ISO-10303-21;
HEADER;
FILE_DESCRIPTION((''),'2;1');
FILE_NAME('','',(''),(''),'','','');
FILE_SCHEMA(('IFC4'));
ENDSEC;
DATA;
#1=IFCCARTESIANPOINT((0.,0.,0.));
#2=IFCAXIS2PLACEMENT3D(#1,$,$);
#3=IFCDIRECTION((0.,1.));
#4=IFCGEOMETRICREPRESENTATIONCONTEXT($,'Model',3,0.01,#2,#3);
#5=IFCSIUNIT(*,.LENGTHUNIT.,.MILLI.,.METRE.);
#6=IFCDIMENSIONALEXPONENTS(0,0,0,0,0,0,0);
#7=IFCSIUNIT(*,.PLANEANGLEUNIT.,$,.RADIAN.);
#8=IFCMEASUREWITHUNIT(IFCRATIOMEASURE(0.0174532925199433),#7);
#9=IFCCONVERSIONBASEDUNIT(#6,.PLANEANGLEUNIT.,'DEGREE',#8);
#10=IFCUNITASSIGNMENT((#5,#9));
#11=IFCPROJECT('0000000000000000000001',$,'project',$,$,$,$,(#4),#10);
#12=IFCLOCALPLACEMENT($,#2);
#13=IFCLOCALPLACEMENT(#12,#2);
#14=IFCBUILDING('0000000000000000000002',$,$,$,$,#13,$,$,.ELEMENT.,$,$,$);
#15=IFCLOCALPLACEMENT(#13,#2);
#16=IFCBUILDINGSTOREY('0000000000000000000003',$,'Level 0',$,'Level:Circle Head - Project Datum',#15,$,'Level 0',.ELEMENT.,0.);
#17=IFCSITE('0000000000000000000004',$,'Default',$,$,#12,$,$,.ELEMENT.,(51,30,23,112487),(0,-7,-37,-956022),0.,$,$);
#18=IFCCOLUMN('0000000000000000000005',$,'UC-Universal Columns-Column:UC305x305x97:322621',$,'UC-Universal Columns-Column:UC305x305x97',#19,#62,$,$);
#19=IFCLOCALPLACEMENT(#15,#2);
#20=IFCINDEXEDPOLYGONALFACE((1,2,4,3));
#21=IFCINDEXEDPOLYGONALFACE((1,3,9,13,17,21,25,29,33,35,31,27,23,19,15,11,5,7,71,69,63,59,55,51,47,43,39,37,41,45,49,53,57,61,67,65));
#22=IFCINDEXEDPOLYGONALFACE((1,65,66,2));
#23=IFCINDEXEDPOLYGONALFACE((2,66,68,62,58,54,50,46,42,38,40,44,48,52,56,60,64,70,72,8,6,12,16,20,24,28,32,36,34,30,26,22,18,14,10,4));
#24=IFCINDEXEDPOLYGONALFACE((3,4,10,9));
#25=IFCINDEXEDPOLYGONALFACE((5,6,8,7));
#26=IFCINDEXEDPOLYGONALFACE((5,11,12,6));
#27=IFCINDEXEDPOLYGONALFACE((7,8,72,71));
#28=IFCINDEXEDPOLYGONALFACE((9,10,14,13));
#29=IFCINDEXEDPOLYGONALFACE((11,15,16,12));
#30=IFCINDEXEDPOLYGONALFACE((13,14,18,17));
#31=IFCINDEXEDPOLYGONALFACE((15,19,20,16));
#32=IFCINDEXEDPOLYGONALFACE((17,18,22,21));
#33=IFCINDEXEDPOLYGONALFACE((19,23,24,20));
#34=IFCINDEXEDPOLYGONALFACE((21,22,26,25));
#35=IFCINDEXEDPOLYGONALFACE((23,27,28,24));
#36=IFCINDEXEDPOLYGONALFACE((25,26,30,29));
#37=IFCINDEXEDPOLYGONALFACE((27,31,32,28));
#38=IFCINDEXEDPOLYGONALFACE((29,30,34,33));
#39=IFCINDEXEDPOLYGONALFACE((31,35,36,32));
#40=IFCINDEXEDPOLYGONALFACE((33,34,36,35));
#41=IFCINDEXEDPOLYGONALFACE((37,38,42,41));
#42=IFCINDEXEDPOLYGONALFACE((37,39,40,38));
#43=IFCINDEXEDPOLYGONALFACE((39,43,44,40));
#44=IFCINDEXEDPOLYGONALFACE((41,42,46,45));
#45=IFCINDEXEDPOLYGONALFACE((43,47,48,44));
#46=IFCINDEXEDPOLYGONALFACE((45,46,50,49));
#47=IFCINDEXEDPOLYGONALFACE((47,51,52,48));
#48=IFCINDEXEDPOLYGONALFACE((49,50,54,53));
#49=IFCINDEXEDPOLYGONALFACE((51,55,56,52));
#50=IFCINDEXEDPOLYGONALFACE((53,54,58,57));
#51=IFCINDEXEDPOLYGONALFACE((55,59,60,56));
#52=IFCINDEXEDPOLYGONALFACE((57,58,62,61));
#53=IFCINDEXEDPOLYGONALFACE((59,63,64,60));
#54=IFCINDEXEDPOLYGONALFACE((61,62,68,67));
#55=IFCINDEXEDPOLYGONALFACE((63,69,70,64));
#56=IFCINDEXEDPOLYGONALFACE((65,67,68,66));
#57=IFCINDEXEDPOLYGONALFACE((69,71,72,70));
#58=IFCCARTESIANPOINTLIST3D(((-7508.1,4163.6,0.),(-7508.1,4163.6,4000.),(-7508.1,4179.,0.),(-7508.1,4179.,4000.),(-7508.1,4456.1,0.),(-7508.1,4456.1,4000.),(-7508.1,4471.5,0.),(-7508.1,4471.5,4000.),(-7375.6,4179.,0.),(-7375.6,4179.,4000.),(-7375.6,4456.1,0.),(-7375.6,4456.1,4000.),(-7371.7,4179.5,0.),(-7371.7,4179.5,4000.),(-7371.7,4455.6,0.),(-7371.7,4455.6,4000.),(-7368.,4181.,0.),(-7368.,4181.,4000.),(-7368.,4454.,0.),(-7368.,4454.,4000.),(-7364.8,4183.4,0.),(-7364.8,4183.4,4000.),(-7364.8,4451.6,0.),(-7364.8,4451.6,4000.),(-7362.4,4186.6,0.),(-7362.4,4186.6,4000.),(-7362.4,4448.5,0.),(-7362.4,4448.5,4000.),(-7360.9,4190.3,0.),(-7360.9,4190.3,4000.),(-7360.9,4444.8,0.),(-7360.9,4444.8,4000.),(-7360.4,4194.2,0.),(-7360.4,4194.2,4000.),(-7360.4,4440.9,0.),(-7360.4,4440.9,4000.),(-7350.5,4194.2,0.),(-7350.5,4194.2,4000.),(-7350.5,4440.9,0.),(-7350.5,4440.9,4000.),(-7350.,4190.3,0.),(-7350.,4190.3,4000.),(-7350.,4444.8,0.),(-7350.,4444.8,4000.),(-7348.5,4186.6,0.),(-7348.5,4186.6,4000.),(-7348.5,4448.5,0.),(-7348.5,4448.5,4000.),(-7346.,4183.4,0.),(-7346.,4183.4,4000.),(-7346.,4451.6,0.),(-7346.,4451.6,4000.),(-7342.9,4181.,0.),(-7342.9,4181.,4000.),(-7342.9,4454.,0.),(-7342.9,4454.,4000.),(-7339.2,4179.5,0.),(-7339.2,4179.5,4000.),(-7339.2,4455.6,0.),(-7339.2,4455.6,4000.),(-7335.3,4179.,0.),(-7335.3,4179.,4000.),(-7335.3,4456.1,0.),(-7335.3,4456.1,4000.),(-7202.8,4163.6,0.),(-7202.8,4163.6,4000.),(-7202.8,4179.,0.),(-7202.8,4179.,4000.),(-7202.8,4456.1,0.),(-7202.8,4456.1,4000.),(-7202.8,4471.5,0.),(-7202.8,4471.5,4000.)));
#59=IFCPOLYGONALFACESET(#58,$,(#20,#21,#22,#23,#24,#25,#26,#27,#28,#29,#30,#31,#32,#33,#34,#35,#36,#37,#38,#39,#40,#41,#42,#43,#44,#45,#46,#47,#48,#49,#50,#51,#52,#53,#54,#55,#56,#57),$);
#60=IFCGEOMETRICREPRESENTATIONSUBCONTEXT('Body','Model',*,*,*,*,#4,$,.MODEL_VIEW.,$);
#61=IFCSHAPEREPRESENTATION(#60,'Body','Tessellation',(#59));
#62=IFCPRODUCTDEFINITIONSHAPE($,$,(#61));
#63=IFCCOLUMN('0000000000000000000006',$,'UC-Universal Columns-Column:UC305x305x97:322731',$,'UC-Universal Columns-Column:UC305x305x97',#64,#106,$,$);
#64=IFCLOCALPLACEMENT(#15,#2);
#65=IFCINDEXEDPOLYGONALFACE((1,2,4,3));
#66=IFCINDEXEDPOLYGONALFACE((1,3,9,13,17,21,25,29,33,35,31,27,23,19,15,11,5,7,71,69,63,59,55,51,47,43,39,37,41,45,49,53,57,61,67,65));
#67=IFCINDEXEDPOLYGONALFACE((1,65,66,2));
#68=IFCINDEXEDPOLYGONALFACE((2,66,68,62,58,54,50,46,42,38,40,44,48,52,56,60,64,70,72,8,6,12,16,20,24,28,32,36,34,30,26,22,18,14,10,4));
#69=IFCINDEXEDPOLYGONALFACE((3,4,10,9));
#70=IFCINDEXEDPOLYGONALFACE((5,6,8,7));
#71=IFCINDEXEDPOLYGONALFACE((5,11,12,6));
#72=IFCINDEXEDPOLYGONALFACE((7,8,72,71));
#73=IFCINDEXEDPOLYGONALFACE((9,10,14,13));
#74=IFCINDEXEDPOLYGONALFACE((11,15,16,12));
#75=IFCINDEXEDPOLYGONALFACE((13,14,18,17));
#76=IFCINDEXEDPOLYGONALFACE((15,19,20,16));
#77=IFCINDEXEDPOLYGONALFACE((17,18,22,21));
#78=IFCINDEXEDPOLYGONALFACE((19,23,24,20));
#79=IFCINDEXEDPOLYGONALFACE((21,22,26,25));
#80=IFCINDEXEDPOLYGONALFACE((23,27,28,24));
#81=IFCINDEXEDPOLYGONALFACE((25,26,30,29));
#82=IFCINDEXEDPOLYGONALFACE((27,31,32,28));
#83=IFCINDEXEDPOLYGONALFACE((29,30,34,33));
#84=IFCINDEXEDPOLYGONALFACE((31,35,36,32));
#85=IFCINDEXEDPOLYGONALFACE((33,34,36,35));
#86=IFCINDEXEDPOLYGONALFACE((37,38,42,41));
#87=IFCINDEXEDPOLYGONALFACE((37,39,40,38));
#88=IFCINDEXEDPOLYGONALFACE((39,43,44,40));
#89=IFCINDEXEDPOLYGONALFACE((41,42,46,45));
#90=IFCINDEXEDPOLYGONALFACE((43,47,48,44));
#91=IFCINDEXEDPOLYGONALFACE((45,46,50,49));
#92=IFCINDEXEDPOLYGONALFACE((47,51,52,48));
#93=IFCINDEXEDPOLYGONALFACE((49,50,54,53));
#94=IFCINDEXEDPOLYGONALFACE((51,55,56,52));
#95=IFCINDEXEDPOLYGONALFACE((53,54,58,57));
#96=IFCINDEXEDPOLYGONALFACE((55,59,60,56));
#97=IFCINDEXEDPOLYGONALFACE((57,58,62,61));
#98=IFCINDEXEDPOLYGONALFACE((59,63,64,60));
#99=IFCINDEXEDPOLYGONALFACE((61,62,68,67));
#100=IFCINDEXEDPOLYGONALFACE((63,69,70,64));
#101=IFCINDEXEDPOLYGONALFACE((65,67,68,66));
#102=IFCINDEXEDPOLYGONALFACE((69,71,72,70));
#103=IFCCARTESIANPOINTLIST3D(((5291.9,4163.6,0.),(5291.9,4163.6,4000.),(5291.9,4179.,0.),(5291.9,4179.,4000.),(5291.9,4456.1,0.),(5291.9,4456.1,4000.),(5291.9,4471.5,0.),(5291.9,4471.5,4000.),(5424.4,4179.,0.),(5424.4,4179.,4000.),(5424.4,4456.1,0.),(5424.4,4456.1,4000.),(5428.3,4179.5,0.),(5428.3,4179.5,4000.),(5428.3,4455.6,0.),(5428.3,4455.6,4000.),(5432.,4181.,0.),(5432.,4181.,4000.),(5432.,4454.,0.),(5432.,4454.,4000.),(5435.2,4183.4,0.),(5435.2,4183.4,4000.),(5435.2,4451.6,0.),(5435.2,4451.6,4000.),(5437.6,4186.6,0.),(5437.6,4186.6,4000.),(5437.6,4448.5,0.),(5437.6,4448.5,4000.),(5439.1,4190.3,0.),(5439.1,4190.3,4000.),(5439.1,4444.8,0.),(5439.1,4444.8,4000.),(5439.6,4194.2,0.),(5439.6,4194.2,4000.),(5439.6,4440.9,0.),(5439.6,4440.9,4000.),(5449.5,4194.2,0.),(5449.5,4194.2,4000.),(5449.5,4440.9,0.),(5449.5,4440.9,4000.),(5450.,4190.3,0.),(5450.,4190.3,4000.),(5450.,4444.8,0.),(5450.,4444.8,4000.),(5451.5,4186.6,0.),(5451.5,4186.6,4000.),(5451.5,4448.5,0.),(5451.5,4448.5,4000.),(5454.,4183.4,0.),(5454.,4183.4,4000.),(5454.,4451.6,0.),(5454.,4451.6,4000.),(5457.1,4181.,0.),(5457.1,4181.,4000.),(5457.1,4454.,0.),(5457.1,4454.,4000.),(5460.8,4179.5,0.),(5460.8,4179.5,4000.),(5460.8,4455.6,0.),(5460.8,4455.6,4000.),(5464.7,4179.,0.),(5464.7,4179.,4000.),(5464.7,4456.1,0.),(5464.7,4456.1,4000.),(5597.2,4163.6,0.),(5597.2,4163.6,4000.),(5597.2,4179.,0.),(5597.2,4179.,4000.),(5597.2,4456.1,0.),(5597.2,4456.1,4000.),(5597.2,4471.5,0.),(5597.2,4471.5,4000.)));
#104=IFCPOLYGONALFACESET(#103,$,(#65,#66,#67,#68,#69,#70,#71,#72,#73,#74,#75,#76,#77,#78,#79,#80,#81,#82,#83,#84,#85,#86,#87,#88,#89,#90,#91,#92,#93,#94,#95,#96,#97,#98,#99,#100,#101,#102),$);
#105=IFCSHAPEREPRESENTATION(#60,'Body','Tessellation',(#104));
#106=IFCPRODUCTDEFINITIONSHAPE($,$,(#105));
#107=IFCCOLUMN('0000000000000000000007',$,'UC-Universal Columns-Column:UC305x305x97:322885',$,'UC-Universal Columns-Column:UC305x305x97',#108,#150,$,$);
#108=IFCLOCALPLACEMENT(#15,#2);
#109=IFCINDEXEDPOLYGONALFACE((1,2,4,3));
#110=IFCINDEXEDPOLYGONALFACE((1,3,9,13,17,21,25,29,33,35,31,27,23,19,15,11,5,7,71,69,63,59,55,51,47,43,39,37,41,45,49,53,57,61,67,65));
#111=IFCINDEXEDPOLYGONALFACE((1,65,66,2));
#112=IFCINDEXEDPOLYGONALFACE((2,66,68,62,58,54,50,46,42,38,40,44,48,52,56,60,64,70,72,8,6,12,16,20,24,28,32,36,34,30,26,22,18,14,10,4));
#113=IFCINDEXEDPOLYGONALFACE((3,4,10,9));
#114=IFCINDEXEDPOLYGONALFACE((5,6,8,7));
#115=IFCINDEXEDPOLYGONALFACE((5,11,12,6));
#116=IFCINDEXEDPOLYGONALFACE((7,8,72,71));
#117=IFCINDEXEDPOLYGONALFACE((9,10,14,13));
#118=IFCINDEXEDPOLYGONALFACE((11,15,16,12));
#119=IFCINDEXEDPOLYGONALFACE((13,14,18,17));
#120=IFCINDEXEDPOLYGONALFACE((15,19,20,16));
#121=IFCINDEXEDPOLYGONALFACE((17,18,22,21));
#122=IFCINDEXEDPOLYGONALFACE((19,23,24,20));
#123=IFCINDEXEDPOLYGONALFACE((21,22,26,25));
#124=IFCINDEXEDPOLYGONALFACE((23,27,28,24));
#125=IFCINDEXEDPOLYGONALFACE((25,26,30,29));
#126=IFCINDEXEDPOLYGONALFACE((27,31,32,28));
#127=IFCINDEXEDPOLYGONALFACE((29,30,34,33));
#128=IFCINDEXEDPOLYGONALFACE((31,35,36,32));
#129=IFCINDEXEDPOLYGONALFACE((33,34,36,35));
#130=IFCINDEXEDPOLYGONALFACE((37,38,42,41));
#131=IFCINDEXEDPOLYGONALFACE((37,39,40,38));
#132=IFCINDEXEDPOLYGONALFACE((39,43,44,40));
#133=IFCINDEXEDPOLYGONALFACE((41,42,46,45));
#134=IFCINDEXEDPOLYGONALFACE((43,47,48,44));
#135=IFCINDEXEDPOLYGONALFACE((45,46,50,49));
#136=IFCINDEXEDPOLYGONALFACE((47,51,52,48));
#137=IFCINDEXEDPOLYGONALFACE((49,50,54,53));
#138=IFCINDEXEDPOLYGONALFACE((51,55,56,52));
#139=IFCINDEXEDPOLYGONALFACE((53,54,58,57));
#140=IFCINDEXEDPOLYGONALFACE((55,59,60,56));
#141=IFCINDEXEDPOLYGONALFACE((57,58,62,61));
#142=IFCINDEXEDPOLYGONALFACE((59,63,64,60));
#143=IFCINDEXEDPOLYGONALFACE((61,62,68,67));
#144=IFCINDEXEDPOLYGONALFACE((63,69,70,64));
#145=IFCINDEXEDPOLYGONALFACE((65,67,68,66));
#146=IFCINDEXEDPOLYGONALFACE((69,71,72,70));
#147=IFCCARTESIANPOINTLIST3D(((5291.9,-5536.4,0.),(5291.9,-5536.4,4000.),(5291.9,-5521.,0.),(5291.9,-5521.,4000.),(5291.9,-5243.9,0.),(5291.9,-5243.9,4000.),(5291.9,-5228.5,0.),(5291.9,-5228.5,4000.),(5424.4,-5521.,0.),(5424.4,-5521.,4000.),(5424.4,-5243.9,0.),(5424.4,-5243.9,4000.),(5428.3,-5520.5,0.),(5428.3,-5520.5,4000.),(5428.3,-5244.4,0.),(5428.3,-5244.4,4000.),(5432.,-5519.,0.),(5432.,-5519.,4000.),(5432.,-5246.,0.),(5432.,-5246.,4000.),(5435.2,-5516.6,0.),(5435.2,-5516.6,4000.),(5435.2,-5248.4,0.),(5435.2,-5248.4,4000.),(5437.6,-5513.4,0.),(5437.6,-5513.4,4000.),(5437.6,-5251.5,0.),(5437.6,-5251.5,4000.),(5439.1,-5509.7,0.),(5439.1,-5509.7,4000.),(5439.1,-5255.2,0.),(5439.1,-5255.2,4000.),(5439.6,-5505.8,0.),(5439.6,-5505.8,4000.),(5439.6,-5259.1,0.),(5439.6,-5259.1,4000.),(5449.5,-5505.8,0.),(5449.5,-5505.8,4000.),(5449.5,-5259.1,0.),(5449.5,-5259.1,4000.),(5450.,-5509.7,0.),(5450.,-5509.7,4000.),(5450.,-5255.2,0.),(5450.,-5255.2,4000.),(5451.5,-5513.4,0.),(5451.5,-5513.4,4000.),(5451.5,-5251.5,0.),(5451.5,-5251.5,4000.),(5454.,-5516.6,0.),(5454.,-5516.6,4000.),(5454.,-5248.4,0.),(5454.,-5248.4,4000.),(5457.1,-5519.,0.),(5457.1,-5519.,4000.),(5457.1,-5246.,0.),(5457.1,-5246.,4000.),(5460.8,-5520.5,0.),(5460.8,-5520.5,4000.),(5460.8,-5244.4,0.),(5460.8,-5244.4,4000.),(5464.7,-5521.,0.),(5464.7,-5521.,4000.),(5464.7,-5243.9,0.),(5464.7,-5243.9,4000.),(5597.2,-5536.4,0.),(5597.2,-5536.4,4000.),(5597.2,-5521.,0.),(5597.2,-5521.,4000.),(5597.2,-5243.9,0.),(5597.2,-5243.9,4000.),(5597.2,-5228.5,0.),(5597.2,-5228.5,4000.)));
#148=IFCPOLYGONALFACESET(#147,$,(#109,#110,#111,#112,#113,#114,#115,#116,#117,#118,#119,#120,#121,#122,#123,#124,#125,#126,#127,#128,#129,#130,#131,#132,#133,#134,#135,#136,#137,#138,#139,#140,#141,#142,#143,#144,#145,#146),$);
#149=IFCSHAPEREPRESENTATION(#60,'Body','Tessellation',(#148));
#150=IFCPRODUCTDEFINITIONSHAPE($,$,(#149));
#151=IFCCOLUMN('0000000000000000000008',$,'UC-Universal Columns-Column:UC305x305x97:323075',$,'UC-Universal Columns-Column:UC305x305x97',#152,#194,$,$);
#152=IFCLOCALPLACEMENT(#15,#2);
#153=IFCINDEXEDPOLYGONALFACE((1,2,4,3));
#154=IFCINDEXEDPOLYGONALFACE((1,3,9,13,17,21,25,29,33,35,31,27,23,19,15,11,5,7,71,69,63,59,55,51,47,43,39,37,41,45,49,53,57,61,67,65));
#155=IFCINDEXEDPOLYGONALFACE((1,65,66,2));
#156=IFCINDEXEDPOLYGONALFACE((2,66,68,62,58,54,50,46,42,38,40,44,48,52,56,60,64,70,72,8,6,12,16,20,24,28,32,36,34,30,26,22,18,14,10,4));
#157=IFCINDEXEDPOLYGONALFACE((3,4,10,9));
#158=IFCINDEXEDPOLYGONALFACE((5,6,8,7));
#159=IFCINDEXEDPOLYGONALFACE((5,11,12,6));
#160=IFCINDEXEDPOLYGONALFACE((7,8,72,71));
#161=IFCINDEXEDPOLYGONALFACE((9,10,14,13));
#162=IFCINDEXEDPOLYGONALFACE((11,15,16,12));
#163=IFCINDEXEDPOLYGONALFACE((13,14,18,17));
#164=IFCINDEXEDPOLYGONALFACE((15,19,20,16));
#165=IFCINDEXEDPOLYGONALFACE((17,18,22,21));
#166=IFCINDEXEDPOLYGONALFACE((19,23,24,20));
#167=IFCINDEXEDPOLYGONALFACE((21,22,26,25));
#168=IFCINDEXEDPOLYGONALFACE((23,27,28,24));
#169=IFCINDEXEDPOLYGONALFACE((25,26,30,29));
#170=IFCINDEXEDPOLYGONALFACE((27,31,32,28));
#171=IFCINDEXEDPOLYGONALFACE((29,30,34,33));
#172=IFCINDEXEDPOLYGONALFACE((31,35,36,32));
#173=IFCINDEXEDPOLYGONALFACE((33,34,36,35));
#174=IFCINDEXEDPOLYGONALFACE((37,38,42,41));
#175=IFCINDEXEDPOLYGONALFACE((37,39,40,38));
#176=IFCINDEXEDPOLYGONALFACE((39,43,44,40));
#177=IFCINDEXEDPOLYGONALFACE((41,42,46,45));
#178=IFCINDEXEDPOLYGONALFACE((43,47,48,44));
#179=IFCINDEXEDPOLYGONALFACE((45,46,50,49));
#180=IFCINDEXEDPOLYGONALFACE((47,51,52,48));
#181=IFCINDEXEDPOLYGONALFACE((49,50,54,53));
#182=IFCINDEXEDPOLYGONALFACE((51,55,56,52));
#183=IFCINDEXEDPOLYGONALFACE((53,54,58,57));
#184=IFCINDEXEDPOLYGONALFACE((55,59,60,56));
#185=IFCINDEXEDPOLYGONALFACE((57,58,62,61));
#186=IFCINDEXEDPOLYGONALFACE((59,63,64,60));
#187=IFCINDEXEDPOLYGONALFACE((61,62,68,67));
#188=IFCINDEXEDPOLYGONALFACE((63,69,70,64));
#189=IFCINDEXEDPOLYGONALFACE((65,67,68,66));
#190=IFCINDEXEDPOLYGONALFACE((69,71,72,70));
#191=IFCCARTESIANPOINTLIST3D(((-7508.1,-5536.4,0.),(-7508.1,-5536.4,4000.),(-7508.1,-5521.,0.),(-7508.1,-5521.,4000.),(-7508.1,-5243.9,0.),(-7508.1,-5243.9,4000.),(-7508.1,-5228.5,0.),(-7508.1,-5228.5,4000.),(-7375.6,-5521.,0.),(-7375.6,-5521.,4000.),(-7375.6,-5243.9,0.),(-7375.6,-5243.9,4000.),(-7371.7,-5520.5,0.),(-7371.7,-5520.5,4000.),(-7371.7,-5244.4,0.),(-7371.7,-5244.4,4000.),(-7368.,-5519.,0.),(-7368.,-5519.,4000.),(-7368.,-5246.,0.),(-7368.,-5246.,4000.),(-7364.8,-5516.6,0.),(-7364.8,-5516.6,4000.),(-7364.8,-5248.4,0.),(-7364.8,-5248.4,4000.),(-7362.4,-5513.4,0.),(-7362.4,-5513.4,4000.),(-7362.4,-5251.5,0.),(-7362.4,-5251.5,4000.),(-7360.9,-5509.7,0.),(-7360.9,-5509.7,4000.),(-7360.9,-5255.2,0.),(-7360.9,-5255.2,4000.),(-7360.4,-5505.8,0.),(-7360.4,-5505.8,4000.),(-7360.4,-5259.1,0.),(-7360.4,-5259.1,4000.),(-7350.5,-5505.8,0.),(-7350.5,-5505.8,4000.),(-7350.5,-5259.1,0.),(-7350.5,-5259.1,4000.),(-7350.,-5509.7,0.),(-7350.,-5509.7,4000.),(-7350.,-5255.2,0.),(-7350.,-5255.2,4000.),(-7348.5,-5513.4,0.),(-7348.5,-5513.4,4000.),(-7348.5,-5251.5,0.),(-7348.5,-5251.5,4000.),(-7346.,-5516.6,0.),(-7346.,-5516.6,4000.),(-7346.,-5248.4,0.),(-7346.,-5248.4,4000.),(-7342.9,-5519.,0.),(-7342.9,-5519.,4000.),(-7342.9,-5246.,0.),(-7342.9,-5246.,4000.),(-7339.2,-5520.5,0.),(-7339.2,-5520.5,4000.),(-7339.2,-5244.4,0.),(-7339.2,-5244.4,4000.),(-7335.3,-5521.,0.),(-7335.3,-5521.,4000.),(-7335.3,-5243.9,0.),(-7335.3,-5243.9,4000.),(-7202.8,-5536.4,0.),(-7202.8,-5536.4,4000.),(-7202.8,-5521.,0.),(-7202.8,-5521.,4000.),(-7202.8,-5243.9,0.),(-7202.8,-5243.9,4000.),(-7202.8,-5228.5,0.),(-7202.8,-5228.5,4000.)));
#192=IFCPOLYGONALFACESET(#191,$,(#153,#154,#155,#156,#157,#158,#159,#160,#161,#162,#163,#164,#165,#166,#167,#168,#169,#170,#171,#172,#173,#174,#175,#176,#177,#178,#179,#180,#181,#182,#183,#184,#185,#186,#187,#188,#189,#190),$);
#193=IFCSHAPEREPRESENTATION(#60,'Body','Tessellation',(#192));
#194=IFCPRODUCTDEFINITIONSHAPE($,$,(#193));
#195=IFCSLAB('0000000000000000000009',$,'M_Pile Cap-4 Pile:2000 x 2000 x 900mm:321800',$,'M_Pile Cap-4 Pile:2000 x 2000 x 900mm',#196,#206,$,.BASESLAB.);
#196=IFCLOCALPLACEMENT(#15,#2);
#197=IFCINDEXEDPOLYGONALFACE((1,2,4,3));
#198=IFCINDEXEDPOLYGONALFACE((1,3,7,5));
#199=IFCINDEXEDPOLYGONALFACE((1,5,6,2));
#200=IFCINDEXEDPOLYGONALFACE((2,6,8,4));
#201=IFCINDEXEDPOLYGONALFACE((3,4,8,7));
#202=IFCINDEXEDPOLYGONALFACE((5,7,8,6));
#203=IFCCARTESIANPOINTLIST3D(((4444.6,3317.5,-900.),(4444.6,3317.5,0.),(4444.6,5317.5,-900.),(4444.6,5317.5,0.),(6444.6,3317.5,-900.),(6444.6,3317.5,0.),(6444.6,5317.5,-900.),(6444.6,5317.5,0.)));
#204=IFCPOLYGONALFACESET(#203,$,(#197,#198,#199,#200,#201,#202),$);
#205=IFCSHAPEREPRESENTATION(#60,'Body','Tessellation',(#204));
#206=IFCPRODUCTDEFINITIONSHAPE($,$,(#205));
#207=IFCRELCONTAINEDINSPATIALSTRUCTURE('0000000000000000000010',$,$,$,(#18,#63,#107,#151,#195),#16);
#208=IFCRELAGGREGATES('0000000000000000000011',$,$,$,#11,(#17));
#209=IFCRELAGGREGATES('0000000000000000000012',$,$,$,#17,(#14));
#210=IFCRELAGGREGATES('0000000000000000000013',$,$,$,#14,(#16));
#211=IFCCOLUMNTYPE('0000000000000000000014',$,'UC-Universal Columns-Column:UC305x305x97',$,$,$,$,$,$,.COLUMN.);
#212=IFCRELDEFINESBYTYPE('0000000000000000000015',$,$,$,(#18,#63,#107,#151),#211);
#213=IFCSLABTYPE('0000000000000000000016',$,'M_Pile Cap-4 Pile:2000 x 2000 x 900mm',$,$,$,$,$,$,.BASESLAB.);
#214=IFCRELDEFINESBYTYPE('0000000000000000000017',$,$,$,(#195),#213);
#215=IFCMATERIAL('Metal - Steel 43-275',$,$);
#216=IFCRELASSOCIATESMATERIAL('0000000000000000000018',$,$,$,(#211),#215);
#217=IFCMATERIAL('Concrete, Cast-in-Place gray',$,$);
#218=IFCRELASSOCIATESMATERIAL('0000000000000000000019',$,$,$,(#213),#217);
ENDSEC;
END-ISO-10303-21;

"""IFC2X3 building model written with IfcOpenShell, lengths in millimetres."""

from ifc_helpers import new_model, entity, si_unit, converted_unit, direction, frame, frame_2d, origin, place, context, subcontext, project, spatial, rectangle, i_section, extrude, source, transform, mapped, material, type_object, type_shapes, element, save


model = new_model("IFC2X3")

# Units and contexts
model_context = context("Model", 3, precision=0.01, world=origin(), true_north=direction((0.0, 1.0)))
body_context = subcontext(model_context, "Body", "Model", "MODEL_VIEW")
ifc_project = project(units=[si_unit("LENGTHUNIT", "METRE", prefix="MILLI"), converted_unit("PLANEANGLEUNIT", "DEGREE", entity("IfcRatioMeasure", 0.0174532925199433), si_unit("PLANEANGLEUNIT", "RADIAN"), dimensions=[0, 0, 0, 0, 0, 0, 0])], contexts=[model_context])

# Site, building, storey
site_placement = place(None, origin())
site = spatial("IfcSite", under=ifc_project, at=site_placement, Name="Default", CompositionType="ELEMENT", RefLatitude=(51, 30, 23, 112487), RefLongitude=(0, -7, -37, -956022), RefElevation=0.0)
building_placement = place(site_placement, origin())
building = spatial("IfcBuilding", under=site, at=building_placement, CompositionType="ELEMENT")
storey_placement = place(building_placement, origin())
storey = spatial("IfcBuildingStorey", under=building, at=storey_placement, Name="Level 0", ObjectType="Level:Circle Head - Project Datum", LongName="Level 0", CompositionType="ELEMENT", Elevation=0.0)

# Columns
ifc_material_1 = material(Name="Metal - Steel 43-275")
column_type = type_object("IfcColumnType", Name="UC-Universal Columns-Column:UC305x305x97", PredefinedType="COLUMN", material=ifc_material_1)
shared_shape = source(origin(), body_context, "Body", "SweptSolid", [
    extrude(i_section(OverallWidth=305.3, OverallDepth=307.9, WebThickness=9.9, FlangeThickness=15.4, FilletRadius=15.2, at=frame_2d((0.0, 0.0), x_axis=(0.0, 1.0))), frame((0.0, 0.0, 0.0), z_axis=(0.0, 0.0, 1.0), x_axis=(0.0, -1.0, 0.0)), (0.0, 0.0, 1.0), 4000.0),
])
type_shapes(column_type, [shared_shape])
for number, where, name in (
    (1, (-7355.4, 4317.5, 0.0), "UC-Universal Columns-Column:UC305x305x97:322621"),
    (2, (5444.6, 4317.5, 0.0), "UC-Universal Columns-Column:UC305x305x97:322731"),
    (3, (5444.6, -5382.5, 0.0), "UC-Universal Columns-Column:UC305x305x97:322885"),
    (4, (-7355.4, -5382.5, 0.0), "UC-Universal Columns-Column:UC305x305x97:323075"),
):
    element("IfcColumn", number, at=place(storey_placement, frame(where)), inside=storey, type_object=column_type, Name=name, ObjectType="UC-Universal Columns-Column:UC305x305x97", context=body_context, shape_type="MappedRepresentation", body=[
        mapped(shared_shape, transform((0.0, 0.0, 0.0), scale=1.0)),
    ])

# Slab
ifc_material_2 = material(Name="Concrete, Cast-in-Place gray")
slab_type_1 = type_object("IfcSlabType", Name="M_Pile Cap-4 Pile:2000 x 2000 x 900mm", PredefinedType="BASESLAB", material=ifc_material_2)
slab_1_placement = place(storey_placement, origin())
element("IfcSlab", 5, at=slab_1_placement, inside=storey, type_object=slab_type_1, Name="M_Pile Cap-4 Pile:2000 x 2000 x 900mm:321800", ObjectType="M_Pile Cap-4 Pile:2000 x 2000 x 900mm", PredefinedType="BASESLAB", context=body_context, shape_type="SweptSolid", body=[
    extrude(rectangle(XDim=2000.0, YDim=2000.0, at=frame_2d((0.0, 0.0), x_axis=(1.0, 0.0))), frame((5444.6, 4317.5, -900.0), z_axis=(0.0, 0.0, 1.0), x_axis=(-1.0, 0.0, 0.0)), (0.0, 0.0, 1.0), 900.0),
])

save(model, "model.ifc")
